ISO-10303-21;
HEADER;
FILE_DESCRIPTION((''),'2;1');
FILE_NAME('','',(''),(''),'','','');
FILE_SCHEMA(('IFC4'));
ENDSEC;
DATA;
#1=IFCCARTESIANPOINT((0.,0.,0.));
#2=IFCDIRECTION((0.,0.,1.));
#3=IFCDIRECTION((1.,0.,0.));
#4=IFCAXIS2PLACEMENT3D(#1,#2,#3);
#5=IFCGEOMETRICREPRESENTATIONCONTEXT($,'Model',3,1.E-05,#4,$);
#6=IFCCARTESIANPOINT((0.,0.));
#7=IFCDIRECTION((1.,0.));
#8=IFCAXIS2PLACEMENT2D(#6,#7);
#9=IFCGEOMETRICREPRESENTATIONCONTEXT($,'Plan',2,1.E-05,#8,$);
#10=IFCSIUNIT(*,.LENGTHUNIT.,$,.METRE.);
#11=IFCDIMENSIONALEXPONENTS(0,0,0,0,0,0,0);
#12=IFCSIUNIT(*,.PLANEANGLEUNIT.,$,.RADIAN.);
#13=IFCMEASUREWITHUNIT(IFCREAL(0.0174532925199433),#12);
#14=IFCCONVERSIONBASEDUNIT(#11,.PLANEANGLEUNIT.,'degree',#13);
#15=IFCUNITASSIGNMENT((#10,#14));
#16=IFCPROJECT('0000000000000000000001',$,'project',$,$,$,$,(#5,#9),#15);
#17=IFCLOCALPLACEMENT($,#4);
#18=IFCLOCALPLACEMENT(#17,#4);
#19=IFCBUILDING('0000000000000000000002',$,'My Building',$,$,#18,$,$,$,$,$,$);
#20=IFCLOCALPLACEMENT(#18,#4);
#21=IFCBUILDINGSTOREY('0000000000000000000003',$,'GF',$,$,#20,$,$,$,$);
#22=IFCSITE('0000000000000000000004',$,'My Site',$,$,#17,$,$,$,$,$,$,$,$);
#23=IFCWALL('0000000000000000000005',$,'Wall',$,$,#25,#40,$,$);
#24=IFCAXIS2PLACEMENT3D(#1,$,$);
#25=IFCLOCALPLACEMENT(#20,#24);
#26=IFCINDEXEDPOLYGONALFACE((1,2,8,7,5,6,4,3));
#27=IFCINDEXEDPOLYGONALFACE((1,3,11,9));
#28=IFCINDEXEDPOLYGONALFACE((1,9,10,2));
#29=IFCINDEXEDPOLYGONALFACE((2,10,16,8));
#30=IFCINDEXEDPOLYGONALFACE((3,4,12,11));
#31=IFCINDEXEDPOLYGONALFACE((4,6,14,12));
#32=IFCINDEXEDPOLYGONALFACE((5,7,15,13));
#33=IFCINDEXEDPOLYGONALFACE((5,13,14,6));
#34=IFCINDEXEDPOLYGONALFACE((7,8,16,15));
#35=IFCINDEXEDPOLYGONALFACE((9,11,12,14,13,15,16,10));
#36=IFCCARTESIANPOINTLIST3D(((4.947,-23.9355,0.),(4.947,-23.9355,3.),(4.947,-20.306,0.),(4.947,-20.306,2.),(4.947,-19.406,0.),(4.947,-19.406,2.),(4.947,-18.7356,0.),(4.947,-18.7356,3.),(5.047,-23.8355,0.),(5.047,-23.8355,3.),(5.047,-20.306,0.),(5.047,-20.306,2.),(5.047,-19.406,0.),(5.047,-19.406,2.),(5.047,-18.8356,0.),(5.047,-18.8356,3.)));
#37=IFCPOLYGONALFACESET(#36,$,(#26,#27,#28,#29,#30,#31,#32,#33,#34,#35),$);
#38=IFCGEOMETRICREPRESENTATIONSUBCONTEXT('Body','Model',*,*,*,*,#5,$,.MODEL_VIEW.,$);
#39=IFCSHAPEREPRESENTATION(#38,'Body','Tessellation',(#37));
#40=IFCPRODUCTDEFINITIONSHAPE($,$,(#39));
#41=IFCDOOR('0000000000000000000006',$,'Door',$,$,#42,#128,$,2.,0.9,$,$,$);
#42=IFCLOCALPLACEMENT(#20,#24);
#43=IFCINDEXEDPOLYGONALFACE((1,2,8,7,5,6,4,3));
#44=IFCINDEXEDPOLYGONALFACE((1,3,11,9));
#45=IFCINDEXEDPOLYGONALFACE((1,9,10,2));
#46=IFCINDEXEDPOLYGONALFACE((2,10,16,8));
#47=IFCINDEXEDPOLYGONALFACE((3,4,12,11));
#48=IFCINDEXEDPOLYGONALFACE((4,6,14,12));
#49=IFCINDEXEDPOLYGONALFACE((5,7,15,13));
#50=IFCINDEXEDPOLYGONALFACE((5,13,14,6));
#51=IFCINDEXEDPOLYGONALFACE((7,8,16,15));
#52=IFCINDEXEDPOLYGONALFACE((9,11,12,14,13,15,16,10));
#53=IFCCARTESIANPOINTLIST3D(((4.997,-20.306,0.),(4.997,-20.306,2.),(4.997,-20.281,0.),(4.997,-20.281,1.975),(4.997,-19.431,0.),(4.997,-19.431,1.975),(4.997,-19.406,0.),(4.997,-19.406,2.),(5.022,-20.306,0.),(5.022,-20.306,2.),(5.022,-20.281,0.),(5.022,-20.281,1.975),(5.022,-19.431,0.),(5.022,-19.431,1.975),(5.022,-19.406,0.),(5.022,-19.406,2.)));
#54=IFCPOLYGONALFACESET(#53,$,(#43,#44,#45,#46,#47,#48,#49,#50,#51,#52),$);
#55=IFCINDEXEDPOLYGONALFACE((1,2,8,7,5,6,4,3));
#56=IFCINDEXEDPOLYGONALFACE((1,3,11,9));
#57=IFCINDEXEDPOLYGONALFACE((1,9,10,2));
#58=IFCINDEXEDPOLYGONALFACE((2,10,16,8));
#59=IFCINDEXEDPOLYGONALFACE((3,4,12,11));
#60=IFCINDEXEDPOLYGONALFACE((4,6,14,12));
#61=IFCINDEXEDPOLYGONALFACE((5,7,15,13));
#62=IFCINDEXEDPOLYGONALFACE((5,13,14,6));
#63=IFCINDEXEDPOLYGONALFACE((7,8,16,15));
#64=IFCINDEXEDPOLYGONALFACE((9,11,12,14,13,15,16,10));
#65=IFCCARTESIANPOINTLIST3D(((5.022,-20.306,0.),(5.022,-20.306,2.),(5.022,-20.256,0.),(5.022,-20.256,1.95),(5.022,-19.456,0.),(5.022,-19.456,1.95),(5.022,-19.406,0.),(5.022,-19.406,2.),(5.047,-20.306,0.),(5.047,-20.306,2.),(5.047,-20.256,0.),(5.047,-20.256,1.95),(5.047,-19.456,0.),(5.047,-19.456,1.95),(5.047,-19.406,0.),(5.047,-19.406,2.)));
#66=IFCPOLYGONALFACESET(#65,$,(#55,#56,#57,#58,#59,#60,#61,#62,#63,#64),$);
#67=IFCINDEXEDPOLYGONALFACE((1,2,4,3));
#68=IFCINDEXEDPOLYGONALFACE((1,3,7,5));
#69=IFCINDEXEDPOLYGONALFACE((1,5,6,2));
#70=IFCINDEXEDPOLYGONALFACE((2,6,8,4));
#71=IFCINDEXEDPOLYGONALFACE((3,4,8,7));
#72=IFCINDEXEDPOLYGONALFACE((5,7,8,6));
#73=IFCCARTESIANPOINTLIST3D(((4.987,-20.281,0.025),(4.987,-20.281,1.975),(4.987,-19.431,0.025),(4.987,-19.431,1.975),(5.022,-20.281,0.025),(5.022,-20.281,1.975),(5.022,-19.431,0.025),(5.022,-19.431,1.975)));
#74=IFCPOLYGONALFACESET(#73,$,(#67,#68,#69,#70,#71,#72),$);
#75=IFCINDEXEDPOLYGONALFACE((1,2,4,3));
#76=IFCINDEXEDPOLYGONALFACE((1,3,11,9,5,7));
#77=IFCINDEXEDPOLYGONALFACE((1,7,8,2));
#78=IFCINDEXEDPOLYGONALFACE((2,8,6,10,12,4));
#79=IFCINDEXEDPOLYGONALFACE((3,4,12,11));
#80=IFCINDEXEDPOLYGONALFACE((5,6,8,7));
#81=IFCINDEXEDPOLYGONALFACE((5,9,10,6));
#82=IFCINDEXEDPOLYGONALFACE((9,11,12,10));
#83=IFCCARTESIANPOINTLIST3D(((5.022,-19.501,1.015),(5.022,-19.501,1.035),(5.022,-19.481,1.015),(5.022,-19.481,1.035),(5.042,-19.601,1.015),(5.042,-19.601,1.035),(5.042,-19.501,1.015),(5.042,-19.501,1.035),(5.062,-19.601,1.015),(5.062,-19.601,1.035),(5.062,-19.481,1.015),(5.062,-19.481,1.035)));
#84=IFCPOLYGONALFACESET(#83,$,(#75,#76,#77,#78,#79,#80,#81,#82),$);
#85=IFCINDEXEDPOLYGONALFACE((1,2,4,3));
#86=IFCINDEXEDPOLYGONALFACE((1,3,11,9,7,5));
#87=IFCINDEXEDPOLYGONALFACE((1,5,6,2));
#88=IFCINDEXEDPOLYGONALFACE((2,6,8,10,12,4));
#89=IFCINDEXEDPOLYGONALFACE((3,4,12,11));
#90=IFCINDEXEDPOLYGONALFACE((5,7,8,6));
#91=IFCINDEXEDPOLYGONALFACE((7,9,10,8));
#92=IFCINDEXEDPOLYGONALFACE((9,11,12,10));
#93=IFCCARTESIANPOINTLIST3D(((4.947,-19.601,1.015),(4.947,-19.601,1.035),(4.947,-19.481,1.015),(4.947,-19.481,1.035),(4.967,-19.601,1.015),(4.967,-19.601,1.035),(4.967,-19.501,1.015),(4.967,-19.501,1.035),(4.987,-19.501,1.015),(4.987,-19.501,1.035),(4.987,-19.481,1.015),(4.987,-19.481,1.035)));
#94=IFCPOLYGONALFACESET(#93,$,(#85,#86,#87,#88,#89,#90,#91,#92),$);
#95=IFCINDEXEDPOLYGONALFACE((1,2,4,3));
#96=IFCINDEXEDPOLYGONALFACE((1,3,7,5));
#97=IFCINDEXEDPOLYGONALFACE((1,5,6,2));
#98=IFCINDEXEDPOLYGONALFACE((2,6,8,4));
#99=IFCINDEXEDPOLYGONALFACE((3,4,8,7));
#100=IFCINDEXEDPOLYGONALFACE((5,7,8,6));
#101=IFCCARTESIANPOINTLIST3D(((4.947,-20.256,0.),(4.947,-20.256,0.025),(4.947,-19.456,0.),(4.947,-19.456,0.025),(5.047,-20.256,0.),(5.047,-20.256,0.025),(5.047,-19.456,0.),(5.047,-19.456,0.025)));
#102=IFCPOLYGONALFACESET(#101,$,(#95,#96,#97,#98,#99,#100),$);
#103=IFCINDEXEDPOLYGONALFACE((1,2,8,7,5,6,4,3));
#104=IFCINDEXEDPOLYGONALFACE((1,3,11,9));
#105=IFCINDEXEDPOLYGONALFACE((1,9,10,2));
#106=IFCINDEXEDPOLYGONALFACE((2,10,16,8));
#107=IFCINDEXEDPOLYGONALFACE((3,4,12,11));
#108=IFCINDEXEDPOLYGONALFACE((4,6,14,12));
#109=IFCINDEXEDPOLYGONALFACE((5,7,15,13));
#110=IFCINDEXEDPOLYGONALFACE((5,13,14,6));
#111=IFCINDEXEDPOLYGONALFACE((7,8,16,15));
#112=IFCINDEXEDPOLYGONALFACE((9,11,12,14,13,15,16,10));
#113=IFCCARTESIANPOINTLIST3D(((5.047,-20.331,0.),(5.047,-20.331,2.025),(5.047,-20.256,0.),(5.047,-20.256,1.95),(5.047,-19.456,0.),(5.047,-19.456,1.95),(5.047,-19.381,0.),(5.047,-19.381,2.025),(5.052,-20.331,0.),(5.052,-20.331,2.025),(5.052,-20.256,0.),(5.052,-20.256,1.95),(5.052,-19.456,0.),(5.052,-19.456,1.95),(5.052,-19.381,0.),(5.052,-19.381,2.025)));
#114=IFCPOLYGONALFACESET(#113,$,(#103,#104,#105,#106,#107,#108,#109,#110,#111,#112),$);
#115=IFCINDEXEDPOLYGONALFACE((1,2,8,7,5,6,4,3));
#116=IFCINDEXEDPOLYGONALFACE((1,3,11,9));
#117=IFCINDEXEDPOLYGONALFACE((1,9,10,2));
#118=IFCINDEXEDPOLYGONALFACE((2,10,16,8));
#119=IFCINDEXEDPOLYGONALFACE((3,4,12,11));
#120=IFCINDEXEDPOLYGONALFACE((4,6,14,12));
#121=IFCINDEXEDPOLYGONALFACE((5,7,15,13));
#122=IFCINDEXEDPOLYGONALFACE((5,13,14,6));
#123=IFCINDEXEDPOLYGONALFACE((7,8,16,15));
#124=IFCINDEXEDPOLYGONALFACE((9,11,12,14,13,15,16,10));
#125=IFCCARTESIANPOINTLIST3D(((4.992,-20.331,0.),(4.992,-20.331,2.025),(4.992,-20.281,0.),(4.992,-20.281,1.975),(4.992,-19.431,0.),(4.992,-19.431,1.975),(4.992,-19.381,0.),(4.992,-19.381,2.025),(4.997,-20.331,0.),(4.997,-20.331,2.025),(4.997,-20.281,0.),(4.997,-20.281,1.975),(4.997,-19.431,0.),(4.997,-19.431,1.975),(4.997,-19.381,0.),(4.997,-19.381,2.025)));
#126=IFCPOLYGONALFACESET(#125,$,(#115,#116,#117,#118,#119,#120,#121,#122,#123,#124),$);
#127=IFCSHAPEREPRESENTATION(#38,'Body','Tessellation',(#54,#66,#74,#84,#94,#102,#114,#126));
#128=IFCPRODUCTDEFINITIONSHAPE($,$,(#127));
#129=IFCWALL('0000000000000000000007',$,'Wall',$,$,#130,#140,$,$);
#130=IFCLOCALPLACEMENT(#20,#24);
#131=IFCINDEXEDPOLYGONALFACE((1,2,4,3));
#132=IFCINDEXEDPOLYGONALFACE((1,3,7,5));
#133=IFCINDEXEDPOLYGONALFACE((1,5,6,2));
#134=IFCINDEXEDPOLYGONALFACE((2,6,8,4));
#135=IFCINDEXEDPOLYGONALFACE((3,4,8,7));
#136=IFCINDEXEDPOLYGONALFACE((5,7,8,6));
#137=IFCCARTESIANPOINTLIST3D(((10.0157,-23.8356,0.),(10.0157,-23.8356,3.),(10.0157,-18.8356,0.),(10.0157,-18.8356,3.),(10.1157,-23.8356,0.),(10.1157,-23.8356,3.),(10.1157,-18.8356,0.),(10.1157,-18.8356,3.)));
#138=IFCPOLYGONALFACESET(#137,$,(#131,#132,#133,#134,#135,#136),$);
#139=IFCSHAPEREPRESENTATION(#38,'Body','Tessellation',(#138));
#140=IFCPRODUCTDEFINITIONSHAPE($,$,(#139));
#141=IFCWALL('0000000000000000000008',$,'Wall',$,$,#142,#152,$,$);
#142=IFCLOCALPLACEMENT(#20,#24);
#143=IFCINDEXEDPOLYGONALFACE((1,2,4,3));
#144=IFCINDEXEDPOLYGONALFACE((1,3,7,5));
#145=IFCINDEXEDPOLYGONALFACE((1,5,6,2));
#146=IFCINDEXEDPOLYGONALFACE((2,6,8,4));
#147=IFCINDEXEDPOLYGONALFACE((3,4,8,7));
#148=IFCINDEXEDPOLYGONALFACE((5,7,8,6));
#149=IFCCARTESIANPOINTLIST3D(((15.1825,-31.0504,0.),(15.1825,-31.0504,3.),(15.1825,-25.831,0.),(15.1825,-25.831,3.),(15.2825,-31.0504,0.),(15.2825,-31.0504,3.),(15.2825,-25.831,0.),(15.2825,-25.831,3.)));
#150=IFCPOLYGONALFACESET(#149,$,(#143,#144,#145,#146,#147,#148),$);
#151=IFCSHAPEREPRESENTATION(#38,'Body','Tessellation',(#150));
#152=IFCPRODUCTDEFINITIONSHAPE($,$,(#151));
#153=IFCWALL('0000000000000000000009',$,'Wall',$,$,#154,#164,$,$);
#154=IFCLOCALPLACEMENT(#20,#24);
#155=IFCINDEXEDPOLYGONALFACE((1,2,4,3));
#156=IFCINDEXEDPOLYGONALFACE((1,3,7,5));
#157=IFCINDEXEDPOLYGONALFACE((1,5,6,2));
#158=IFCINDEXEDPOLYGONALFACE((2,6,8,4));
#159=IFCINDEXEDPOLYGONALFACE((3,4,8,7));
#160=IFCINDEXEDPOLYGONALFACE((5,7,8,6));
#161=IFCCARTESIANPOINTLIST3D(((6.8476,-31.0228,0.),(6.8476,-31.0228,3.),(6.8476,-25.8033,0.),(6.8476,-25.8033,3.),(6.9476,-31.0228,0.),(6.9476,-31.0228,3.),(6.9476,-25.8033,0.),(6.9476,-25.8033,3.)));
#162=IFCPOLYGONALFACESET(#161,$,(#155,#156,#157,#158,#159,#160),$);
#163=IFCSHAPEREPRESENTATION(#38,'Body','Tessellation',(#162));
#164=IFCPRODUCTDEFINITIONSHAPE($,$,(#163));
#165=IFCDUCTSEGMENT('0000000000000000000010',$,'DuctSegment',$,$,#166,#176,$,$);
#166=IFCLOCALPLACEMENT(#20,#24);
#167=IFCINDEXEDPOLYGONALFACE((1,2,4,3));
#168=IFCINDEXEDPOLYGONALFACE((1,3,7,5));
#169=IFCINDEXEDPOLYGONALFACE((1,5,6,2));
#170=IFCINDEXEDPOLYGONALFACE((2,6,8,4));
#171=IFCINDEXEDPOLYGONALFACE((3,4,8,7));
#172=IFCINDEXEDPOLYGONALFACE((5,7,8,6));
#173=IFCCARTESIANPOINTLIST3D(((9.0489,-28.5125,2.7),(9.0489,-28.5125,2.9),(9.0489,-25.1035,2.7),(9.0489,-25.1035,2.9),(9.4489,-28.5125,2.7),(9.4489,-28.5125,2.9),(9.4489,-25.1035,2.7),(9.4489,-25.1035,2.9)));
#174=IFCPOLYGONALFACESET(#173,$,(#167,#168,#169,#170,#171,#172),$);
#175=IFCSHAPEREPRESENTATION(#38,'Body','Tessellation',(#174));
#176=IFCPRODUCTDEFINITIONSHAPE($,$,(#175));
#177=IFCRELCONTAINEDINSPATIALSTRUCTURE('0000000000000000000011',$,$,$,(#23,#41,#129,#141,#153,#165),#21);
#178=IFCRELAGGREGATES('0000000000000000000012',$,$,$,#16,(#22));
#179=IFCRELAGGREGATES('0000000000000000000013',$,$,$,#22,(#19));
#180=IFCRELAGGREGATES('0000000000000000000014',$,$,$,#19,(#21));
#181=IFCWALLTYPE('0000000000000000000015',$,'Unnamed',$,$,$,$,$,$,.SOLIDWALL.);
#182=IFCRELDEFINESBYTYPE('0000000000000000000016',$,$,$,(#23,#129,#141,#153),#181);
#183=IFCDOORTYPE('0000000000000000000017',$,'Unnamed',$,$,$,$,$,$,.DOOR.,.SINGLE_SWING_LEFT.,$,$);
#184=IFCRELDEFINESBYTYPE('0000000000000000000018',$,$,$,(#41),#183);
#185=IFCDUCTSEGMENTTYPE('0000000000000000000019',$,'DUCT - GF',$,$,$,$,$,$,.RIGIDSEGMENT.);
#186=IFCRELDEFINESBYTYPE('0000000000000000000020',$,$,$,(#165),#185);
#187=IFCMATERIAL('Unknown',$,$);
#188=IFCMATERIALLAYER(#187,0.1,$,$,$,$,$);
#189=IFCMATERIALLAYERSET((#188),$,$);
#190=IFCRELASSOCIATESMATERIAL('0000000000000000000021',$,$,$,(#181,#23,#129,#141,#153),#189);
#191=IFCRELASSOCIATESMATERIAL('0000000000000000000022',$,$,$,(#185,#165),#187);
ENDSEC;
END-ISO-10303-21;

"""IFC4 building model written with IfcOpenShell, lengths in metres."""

from ifc_helpers import new_model, entity, si_unit, converted_unit, frame, origin_with_axes, origin_2d_with_axis, place, context, subcontext, project, spatial, line, indexed_curve, rectangle, outline, extrude, shape, source, transform, mapped, material, layer, layer_set, layer_usage, material_profile, profile_set, profile_usage, type_object, type_shapes, element, fill, save


model = new_model("IFC4")

# Units and contexts
model_context = context("Model", 3, precision=1e-05, world=origin_with_axes())
plan_context = context("Plan", 2, precision=1e-05, world=origin_2d_with_axis())
body_context_1 = subcontext(model_context, "Body", "Model", "MODEL_VIEW")
body_context_2 = subcontext(plan_context, "Body", "Plan", "PLAN_VIEW")
ifc_project = project(units=[si_unit("LENGTHUNIT", "METRE"), converted_unit("PLANEANGLEUNIT", "degree", entity("IfcReal", 0.0174532925199433), si_unit("PLANEANGLEUNIT", "RADIAN"), dimensions=[0, 0, 0, 0, 0, 0, 0])], contexts=[model_context, plan_context])

# Site, building, storey
site_placement = place(None, origin_with_axes())
site = spatial("IfcSite", under=ifc_project, at=site_placement, Name="My Site")
building_placement = place(site_placement, origin_with_axes())
building = spatial("IfcBuilding", under=site, at=building_placement, Name="My Building")
storey_placement = place(building_placement, origin_with_axes())
storey = spatial("IfcBuildingStorey", under=building, at=storey_placement, Name="GF")

# Shared definitions
ifc_material = material(Name="Unknown")
ifc_layer = layer(ifc_material, 0.1)
ifc_layer_set = layer_set([ifc_layer])
wall_type = type_object("IfcWallType", Name="Unnamed", PredefinedType="SOLIDWALL", material=ifc_layer_set)

# Shared definitions
shared_shape_1 = source(origin_with_axes(), body_context_1, "Body", "SweptSolid", [
    extrude(outline(indexed_curve([(0.0, 0.0), (0.9, 0.0), (0.9, 2.0), (0.0, 2.0)], segments=[line(1, 2, 3, 4, 1)])), frame((0.0, -0.6, 0.0), z_axis=(0.0, -1.0, 0.0), x_axis=(1.0, 0.0, 0.0)), (0.0, 0.0, -1.0), 1.2),
])
door_type = type_object("IfcDoorType", Name="Unnamed", OperationType="SINGLE_SWING_LEFT", PredefinedType="DOOR")
shared_shape_2 = source(origin_with_axes(), body_context_1, "Body", "SweptSolid", [
    extrude(outline(indexed_curve([(0.0, 0.0), (0.0, 2.0), (0.9, 2.0), (0.9, 0.0), (0.875, 0.0), (0.875, 1.975), (0.025, 1.975), (0.025, 0.0)], segments=[line(1, 2, 3, 4, 5, 6, 7, 8, 1)])), frame((0.0, 0.025, 0.0), z_axis=(0.0, -1.0, 0.0), x_axis=(1.0, 0.0, 0.0)), (0.0, 0.0, -1.0), 0.025),
    extrude(outline(indexed_curve([(0.0, 0.0), (0.0, 2.0), (0.9, 2.0), (0.9, 0.0), (0.85, 0.0), (0.85, 1.95), (0.05, 1.95), (0.05, 0.0)], segments=[line(1, 2, 3, 4, 5, 6, 7, 8, 1)])), frame((0.0, 0.0, 0.0), z_axis=(0.0, -1.0, 0.0), x_axis=(1.0, 0.0, 0.0)), (0.0, 0.0, -1.0), 0.025),
    extrude(outline(indexed_curve([(0.0, 0.0), (0.85, 0.0), (0.85, 0.035), (0.0, 0.035)], segments=[line(1, 2, 3, 4, 1)])), frame((0.025, 0.025, 0.025), z_axis=(0.0, 0.0, 1.0), x_axis=(1.0, 0.0, 0.0)), (0.0, 0.0, 1.0), 1.95),
    extrude(outline(indexed_curve([(0.0, 0.0), (0.0, -0.04), (-0.12, -0.04), (-0.12, -0.02), (-0.02, -0.02), (-0.02, 0.0)], segments=[line(1, 2, 3, 4, 5, 6, 1)])), frame((0.825, 0.025, 1.015), z_axis=(0.0, 0.0, 1.0), x_axis=(1.0, 0.0, 0.0)), (0.0, 0.0, 1.0), 0.02),
    extrude(outline(indexed_curve([(0.0, 0.0), (0.0, 0.04), (-0.12, 0.04), (-0.12, 0.02), (-0.02, 0.02), (-0.02, 0.0)], segments=[line(1, 2, 3, 4, 5, 6, 1)])), frame((0.825, 0.06, 1.015), z_axis=(0.0, 0.0, 1.0), x_axis=(1.0, 0.0, 0.0)), (0.0, 0.0, 1.0), 0.02),
    extrude(outline(indexed_curve([(0.0, 0.0), (0.8, 0.0), (0.8, 0.1), (0.0, 0.1)], segments=[line(1, 2, 3, 4, 1)])), frame((0.05, 0.0, 0.0), z_axis=(0.0, 0.0, 1.0), x_axis=(1.0, 0.0, 0.0)), (0.0, 0.0, 1.0), 0.025),
    extrude(outline(indexed_curve([(0.0, 0.0), (0.0, 2.025), (0.95, 2.025), (0.95, 0.0), (0.875, 0.0), (0.875, 1.95), (0.075, 1.95), (0.075, 0.0)], segments=[line(1, 2, 3, 4, 5, 6, 7, 8, 1)])), frame((-0.025, -0.005, 0.0), z_axis=(0.0, -1.0, 0.0), x_axis=(1.0, 0.0, 0.0)), (0.0, 0.0, -1.0), 0.005),
    extrude(outline(indexed_curve([(0.0, 0.0), (0.0, 2.025), (0.95, 2.025), (0.95, 0.0), (0.9, 0.0), (0.9, 1.975), (0.05, 1.975), (0.05, 0.0)], segments=[line(1, 2, 3, 4, 5, 6, 7, 8, 1)])), frame((-0.025, 0.05, 0.0), z_axis=(0.0, -1.0, 0.0), x_axis=(1.0, 0.0, 0.0)), (0.0, 0.0, -1.0), 0.005),
])
shared_shape_3 = source(origin_with_axes(), body_context_2, "Body", "Curve2D", [
    entity("IfcIndexedPolyCurve", entity("IfcCartesianPointList2D", [[0.0, 0.0], [0.0, 0.05], [0.025, 0.05], [0.025, 0.025], [0.05, 0.025], [0.05, 0.0]]), [entity("IfcLineIndex", [1, 2, 3, 4, 5, 6, 1])]),
    entity("IfcIndexedPolyCurve", entity("IfcCartesianPointList2D", [[0.9, 0.0], [0.9, 0.05], [0.875, 0.05], [0.875, 0.025], [0.85, 0.025], [0.85, 0.0]]), [entity("IfcLineIndex", [1, 2, 3, 4, 5, 6, 1])]),
    entity("IfcTrimmedCurve", entity("IfcEllipse", entity("IfcAxis2Placement2D", entity("IfcCartesianPoint", [0.06, 0.05]), entity("IfcDirection", [1.0, 0.0])), 0.815, 0.85), [entity("IfcCartesianPoint", [0.875, 0.05])], [entity("IfcCartesianPoint", [0.06, 0.9])], True, "CARTESIAN"),
    entity("IfcIndexedPolyCurve", entity("IfcCartesianPointList2D", [[0.025, 0.05], [0.06, 0.05], [0.06, 0.9], [0.025, 0.9]]), [entity("IfcLineIndex", [1, 2, 3, 4, 1])]),
])
type_shapes(door_type, [shared_shape_2, shared_shape_3])

# Wall, opening, door
ifc_layer_usage_1 = layer_usage(ifc_layer_set, "AXIS2", "POSITIVE", 0.0)
wall_1_placement = place(storey_placement, frame((5.047, -23.8355, 0.0), z_axis=(0.0, 0.0, 1.0), x_axis=(0.0, 1.0, 0.0)))
wall_1 = element("IfcWall", 1, at=wall_1_placement, inside=storey, type_object=wall_type, material=ifc_layer_usage_1, Name="Wall", context=body_context_1, shape_type="SweptSolid", body=[
    extrude(outline(indexed_curve([(0.0, 0.0), (-0.1, 0.1), (5.1, 0.1), (5.0, 0.0)], segments=[line(1, 2, 3, 4, 1)])), origin_with_axes(), (0.0, 0.0, 1.0), 3.0),
])
opening_1_placement = place(wall_1_placement, frame((3.5295, 0.0, 0.0), z_axis=(0.0, 0.0, 1.0), x_axis=(1.0, 0.0, 0.0)))
opening_1 = element("IfcOpeningElement", 2, at=opening_1_placement, cuts=wall_1, PredefinedType="OPENING", context=body_context_1, shape_type="MappedRepresentation", body=[
    mapped(shared_shape_1, transform((0.0, 0.0, 0.0), x_axis=(1.0, 0.0, 0.0), y_axis=(0.0, 1.0, 0.0), z_axis=(0.0, 0.0, 1.0), scale=1.0)),
])
door_1_placement = place(opening_1_placement, frame((0.0, 0.0, 0.0), z_axis=(0.0, 0.0, 1.0), x_axis=(1.0, 0.0, 0.0)))
door_1 = element("IfcDoor", 3, at=door_1_placement, inside=storey, type_object=door_type, Name="Door", OverallHeight=2.0, OverallWidth=0.9, shapes=[
    shape(body_context_1, "Body", "MappedRepresentation", [mapped(shared_shape_2, transform((0.0, 0.0, 0.0), x_axis=(1.0, 0.0, 0.0), y_axis=(0.0, 1.0, 0.0), z_axis=(0.0, 0.0, 1.0), scale=1.0))]),
    shape(body_context_2, "Body", "MappedRepresentation", [mapped(shared_shape_3, transform((0.0, 0.0, 0.0), x_axis=(1.0, 0.0, 0.0), y_axis=(0.0, 1.0, 0.0), z_axis=(0.0, 0.0, 1.0), scale=1.0))]),
])
fill(opening_1, door_1)

# Walls
ifc_layer_usage_2 = layer_usage(ifc_layer_set, "AXIS2", "POSITIVE", 0.0)
wall_2_placement = place(storey_placement, frame((10.0157, -18.8356, 0.0), z_axis=(0.0, 0.0, 1.0), x_axis=(0.0, -1.0, 0.0)))
element("IfcWall", 4, at=wall_2_placement, inside=storey, type_object=wall_type, material=ifc_layer_usage_2, Name="Wall", context=body_context_1, shape_type="SweptSolid", body=[
    extrude(outline(indexed_curve([(0.0, 0.0), (0.0, 0.1), (5.0, 0.1), (5.0, 0.0)], segments=[line(1, 2, 3, 4, 1)])), origin_with_axes(), (0.0, 0.0, 1.0), 3.0),
])
ifc_layer_usage_3 = layer_usage(ifc_layer_set, "AXIS2", "POSITIVE", 0.0)
wall_3_placement = place(storey_placement, frame((15.1825, -25.831, 0.0), z_axis=(0.0, 0.0, 1.0), x_axis=(0.0, -1.0, 0.0)))
element("IfcWall", 5, at=wall_3_placement, inside=storey, type_object=wall_type, material=ifc_layer_usage_3, Name="Wall", context=body_context_1, shape_type="SweptSolid", body=[
    extrude(outline(indexed_curve([(0.0, 0.0), (0.0, 0.1), (5.2194, 0.1), (5.2194, 0.0)], segments=[line(1, 2, 3, 4, 1)])), origin_with_axes(), (0.0, 0.0, 1.0), 3.0),
])
ifc_layer_usage_4 = layer_usage(ifc_layer_set, "AXIS2", "POSITIVE", 0.0)
wall_4_placement = place(storey_placement, frame((6.8476, -25.8033, 0.0), z_axis=(0.0, 0.0, 1.0), x_axis=(0.0, -1.0, 0.0)))
element("IfcWall", 6, at=wall_4_placement, inside=storey, type_object=wall_type, material=ifc_layer_usage_4, Name="Wall", context=body_context_1, shape_type="SweptSolid", body=[
    extrude(outline(indexed_curve([(0.0, 0.0), (0.0, 0.1), (5.2195, 0.1), (5.2195, 0.0)], segments=[line(1, 2, 3, 4, 1)])), origin_with_axes(), (0.0, 0.0, 1.0), 3.0),
])

# Duct segment
ifc_material_profile_1 = material_profile(ifc_material, rectangle(XDim=0.4, YDim=0.2))
ifc_profile_set_1 = profile_set([ifc_material_profile_1])
ifc_profile_usage_1 = profile_usage(ifc_profile_set_1, cardinal=5)
duct_segment_type = type_object("IfcDuctSegmentType", Name="DUCT - GF", PredefinedType="RIGIDSEGMENT", material=ifc_profile_set_1)
duct_segment_1_placement = place(storey_placement, frame((9.2489, -28.5125, 2.8), z_axis=(0.0, 1.0, 0.0), x_axis=(-1.0, 0.0, 0.0)))
element("IfcDuctSegment", 7, at=duct_segment_1_placement, inside=storey, type_object=duct_segment_type, material=ifc_profile_usage_1, Name="DuctSegment", context=body_context_1, shape_type="SweptSolid", body=[
    extrude(rectangle(XDim=0.4, YDim=0.2), origin_with_axes(), (0.0, 0.0, 1.0), 3.409),
])

save(model, "model.ifc")
